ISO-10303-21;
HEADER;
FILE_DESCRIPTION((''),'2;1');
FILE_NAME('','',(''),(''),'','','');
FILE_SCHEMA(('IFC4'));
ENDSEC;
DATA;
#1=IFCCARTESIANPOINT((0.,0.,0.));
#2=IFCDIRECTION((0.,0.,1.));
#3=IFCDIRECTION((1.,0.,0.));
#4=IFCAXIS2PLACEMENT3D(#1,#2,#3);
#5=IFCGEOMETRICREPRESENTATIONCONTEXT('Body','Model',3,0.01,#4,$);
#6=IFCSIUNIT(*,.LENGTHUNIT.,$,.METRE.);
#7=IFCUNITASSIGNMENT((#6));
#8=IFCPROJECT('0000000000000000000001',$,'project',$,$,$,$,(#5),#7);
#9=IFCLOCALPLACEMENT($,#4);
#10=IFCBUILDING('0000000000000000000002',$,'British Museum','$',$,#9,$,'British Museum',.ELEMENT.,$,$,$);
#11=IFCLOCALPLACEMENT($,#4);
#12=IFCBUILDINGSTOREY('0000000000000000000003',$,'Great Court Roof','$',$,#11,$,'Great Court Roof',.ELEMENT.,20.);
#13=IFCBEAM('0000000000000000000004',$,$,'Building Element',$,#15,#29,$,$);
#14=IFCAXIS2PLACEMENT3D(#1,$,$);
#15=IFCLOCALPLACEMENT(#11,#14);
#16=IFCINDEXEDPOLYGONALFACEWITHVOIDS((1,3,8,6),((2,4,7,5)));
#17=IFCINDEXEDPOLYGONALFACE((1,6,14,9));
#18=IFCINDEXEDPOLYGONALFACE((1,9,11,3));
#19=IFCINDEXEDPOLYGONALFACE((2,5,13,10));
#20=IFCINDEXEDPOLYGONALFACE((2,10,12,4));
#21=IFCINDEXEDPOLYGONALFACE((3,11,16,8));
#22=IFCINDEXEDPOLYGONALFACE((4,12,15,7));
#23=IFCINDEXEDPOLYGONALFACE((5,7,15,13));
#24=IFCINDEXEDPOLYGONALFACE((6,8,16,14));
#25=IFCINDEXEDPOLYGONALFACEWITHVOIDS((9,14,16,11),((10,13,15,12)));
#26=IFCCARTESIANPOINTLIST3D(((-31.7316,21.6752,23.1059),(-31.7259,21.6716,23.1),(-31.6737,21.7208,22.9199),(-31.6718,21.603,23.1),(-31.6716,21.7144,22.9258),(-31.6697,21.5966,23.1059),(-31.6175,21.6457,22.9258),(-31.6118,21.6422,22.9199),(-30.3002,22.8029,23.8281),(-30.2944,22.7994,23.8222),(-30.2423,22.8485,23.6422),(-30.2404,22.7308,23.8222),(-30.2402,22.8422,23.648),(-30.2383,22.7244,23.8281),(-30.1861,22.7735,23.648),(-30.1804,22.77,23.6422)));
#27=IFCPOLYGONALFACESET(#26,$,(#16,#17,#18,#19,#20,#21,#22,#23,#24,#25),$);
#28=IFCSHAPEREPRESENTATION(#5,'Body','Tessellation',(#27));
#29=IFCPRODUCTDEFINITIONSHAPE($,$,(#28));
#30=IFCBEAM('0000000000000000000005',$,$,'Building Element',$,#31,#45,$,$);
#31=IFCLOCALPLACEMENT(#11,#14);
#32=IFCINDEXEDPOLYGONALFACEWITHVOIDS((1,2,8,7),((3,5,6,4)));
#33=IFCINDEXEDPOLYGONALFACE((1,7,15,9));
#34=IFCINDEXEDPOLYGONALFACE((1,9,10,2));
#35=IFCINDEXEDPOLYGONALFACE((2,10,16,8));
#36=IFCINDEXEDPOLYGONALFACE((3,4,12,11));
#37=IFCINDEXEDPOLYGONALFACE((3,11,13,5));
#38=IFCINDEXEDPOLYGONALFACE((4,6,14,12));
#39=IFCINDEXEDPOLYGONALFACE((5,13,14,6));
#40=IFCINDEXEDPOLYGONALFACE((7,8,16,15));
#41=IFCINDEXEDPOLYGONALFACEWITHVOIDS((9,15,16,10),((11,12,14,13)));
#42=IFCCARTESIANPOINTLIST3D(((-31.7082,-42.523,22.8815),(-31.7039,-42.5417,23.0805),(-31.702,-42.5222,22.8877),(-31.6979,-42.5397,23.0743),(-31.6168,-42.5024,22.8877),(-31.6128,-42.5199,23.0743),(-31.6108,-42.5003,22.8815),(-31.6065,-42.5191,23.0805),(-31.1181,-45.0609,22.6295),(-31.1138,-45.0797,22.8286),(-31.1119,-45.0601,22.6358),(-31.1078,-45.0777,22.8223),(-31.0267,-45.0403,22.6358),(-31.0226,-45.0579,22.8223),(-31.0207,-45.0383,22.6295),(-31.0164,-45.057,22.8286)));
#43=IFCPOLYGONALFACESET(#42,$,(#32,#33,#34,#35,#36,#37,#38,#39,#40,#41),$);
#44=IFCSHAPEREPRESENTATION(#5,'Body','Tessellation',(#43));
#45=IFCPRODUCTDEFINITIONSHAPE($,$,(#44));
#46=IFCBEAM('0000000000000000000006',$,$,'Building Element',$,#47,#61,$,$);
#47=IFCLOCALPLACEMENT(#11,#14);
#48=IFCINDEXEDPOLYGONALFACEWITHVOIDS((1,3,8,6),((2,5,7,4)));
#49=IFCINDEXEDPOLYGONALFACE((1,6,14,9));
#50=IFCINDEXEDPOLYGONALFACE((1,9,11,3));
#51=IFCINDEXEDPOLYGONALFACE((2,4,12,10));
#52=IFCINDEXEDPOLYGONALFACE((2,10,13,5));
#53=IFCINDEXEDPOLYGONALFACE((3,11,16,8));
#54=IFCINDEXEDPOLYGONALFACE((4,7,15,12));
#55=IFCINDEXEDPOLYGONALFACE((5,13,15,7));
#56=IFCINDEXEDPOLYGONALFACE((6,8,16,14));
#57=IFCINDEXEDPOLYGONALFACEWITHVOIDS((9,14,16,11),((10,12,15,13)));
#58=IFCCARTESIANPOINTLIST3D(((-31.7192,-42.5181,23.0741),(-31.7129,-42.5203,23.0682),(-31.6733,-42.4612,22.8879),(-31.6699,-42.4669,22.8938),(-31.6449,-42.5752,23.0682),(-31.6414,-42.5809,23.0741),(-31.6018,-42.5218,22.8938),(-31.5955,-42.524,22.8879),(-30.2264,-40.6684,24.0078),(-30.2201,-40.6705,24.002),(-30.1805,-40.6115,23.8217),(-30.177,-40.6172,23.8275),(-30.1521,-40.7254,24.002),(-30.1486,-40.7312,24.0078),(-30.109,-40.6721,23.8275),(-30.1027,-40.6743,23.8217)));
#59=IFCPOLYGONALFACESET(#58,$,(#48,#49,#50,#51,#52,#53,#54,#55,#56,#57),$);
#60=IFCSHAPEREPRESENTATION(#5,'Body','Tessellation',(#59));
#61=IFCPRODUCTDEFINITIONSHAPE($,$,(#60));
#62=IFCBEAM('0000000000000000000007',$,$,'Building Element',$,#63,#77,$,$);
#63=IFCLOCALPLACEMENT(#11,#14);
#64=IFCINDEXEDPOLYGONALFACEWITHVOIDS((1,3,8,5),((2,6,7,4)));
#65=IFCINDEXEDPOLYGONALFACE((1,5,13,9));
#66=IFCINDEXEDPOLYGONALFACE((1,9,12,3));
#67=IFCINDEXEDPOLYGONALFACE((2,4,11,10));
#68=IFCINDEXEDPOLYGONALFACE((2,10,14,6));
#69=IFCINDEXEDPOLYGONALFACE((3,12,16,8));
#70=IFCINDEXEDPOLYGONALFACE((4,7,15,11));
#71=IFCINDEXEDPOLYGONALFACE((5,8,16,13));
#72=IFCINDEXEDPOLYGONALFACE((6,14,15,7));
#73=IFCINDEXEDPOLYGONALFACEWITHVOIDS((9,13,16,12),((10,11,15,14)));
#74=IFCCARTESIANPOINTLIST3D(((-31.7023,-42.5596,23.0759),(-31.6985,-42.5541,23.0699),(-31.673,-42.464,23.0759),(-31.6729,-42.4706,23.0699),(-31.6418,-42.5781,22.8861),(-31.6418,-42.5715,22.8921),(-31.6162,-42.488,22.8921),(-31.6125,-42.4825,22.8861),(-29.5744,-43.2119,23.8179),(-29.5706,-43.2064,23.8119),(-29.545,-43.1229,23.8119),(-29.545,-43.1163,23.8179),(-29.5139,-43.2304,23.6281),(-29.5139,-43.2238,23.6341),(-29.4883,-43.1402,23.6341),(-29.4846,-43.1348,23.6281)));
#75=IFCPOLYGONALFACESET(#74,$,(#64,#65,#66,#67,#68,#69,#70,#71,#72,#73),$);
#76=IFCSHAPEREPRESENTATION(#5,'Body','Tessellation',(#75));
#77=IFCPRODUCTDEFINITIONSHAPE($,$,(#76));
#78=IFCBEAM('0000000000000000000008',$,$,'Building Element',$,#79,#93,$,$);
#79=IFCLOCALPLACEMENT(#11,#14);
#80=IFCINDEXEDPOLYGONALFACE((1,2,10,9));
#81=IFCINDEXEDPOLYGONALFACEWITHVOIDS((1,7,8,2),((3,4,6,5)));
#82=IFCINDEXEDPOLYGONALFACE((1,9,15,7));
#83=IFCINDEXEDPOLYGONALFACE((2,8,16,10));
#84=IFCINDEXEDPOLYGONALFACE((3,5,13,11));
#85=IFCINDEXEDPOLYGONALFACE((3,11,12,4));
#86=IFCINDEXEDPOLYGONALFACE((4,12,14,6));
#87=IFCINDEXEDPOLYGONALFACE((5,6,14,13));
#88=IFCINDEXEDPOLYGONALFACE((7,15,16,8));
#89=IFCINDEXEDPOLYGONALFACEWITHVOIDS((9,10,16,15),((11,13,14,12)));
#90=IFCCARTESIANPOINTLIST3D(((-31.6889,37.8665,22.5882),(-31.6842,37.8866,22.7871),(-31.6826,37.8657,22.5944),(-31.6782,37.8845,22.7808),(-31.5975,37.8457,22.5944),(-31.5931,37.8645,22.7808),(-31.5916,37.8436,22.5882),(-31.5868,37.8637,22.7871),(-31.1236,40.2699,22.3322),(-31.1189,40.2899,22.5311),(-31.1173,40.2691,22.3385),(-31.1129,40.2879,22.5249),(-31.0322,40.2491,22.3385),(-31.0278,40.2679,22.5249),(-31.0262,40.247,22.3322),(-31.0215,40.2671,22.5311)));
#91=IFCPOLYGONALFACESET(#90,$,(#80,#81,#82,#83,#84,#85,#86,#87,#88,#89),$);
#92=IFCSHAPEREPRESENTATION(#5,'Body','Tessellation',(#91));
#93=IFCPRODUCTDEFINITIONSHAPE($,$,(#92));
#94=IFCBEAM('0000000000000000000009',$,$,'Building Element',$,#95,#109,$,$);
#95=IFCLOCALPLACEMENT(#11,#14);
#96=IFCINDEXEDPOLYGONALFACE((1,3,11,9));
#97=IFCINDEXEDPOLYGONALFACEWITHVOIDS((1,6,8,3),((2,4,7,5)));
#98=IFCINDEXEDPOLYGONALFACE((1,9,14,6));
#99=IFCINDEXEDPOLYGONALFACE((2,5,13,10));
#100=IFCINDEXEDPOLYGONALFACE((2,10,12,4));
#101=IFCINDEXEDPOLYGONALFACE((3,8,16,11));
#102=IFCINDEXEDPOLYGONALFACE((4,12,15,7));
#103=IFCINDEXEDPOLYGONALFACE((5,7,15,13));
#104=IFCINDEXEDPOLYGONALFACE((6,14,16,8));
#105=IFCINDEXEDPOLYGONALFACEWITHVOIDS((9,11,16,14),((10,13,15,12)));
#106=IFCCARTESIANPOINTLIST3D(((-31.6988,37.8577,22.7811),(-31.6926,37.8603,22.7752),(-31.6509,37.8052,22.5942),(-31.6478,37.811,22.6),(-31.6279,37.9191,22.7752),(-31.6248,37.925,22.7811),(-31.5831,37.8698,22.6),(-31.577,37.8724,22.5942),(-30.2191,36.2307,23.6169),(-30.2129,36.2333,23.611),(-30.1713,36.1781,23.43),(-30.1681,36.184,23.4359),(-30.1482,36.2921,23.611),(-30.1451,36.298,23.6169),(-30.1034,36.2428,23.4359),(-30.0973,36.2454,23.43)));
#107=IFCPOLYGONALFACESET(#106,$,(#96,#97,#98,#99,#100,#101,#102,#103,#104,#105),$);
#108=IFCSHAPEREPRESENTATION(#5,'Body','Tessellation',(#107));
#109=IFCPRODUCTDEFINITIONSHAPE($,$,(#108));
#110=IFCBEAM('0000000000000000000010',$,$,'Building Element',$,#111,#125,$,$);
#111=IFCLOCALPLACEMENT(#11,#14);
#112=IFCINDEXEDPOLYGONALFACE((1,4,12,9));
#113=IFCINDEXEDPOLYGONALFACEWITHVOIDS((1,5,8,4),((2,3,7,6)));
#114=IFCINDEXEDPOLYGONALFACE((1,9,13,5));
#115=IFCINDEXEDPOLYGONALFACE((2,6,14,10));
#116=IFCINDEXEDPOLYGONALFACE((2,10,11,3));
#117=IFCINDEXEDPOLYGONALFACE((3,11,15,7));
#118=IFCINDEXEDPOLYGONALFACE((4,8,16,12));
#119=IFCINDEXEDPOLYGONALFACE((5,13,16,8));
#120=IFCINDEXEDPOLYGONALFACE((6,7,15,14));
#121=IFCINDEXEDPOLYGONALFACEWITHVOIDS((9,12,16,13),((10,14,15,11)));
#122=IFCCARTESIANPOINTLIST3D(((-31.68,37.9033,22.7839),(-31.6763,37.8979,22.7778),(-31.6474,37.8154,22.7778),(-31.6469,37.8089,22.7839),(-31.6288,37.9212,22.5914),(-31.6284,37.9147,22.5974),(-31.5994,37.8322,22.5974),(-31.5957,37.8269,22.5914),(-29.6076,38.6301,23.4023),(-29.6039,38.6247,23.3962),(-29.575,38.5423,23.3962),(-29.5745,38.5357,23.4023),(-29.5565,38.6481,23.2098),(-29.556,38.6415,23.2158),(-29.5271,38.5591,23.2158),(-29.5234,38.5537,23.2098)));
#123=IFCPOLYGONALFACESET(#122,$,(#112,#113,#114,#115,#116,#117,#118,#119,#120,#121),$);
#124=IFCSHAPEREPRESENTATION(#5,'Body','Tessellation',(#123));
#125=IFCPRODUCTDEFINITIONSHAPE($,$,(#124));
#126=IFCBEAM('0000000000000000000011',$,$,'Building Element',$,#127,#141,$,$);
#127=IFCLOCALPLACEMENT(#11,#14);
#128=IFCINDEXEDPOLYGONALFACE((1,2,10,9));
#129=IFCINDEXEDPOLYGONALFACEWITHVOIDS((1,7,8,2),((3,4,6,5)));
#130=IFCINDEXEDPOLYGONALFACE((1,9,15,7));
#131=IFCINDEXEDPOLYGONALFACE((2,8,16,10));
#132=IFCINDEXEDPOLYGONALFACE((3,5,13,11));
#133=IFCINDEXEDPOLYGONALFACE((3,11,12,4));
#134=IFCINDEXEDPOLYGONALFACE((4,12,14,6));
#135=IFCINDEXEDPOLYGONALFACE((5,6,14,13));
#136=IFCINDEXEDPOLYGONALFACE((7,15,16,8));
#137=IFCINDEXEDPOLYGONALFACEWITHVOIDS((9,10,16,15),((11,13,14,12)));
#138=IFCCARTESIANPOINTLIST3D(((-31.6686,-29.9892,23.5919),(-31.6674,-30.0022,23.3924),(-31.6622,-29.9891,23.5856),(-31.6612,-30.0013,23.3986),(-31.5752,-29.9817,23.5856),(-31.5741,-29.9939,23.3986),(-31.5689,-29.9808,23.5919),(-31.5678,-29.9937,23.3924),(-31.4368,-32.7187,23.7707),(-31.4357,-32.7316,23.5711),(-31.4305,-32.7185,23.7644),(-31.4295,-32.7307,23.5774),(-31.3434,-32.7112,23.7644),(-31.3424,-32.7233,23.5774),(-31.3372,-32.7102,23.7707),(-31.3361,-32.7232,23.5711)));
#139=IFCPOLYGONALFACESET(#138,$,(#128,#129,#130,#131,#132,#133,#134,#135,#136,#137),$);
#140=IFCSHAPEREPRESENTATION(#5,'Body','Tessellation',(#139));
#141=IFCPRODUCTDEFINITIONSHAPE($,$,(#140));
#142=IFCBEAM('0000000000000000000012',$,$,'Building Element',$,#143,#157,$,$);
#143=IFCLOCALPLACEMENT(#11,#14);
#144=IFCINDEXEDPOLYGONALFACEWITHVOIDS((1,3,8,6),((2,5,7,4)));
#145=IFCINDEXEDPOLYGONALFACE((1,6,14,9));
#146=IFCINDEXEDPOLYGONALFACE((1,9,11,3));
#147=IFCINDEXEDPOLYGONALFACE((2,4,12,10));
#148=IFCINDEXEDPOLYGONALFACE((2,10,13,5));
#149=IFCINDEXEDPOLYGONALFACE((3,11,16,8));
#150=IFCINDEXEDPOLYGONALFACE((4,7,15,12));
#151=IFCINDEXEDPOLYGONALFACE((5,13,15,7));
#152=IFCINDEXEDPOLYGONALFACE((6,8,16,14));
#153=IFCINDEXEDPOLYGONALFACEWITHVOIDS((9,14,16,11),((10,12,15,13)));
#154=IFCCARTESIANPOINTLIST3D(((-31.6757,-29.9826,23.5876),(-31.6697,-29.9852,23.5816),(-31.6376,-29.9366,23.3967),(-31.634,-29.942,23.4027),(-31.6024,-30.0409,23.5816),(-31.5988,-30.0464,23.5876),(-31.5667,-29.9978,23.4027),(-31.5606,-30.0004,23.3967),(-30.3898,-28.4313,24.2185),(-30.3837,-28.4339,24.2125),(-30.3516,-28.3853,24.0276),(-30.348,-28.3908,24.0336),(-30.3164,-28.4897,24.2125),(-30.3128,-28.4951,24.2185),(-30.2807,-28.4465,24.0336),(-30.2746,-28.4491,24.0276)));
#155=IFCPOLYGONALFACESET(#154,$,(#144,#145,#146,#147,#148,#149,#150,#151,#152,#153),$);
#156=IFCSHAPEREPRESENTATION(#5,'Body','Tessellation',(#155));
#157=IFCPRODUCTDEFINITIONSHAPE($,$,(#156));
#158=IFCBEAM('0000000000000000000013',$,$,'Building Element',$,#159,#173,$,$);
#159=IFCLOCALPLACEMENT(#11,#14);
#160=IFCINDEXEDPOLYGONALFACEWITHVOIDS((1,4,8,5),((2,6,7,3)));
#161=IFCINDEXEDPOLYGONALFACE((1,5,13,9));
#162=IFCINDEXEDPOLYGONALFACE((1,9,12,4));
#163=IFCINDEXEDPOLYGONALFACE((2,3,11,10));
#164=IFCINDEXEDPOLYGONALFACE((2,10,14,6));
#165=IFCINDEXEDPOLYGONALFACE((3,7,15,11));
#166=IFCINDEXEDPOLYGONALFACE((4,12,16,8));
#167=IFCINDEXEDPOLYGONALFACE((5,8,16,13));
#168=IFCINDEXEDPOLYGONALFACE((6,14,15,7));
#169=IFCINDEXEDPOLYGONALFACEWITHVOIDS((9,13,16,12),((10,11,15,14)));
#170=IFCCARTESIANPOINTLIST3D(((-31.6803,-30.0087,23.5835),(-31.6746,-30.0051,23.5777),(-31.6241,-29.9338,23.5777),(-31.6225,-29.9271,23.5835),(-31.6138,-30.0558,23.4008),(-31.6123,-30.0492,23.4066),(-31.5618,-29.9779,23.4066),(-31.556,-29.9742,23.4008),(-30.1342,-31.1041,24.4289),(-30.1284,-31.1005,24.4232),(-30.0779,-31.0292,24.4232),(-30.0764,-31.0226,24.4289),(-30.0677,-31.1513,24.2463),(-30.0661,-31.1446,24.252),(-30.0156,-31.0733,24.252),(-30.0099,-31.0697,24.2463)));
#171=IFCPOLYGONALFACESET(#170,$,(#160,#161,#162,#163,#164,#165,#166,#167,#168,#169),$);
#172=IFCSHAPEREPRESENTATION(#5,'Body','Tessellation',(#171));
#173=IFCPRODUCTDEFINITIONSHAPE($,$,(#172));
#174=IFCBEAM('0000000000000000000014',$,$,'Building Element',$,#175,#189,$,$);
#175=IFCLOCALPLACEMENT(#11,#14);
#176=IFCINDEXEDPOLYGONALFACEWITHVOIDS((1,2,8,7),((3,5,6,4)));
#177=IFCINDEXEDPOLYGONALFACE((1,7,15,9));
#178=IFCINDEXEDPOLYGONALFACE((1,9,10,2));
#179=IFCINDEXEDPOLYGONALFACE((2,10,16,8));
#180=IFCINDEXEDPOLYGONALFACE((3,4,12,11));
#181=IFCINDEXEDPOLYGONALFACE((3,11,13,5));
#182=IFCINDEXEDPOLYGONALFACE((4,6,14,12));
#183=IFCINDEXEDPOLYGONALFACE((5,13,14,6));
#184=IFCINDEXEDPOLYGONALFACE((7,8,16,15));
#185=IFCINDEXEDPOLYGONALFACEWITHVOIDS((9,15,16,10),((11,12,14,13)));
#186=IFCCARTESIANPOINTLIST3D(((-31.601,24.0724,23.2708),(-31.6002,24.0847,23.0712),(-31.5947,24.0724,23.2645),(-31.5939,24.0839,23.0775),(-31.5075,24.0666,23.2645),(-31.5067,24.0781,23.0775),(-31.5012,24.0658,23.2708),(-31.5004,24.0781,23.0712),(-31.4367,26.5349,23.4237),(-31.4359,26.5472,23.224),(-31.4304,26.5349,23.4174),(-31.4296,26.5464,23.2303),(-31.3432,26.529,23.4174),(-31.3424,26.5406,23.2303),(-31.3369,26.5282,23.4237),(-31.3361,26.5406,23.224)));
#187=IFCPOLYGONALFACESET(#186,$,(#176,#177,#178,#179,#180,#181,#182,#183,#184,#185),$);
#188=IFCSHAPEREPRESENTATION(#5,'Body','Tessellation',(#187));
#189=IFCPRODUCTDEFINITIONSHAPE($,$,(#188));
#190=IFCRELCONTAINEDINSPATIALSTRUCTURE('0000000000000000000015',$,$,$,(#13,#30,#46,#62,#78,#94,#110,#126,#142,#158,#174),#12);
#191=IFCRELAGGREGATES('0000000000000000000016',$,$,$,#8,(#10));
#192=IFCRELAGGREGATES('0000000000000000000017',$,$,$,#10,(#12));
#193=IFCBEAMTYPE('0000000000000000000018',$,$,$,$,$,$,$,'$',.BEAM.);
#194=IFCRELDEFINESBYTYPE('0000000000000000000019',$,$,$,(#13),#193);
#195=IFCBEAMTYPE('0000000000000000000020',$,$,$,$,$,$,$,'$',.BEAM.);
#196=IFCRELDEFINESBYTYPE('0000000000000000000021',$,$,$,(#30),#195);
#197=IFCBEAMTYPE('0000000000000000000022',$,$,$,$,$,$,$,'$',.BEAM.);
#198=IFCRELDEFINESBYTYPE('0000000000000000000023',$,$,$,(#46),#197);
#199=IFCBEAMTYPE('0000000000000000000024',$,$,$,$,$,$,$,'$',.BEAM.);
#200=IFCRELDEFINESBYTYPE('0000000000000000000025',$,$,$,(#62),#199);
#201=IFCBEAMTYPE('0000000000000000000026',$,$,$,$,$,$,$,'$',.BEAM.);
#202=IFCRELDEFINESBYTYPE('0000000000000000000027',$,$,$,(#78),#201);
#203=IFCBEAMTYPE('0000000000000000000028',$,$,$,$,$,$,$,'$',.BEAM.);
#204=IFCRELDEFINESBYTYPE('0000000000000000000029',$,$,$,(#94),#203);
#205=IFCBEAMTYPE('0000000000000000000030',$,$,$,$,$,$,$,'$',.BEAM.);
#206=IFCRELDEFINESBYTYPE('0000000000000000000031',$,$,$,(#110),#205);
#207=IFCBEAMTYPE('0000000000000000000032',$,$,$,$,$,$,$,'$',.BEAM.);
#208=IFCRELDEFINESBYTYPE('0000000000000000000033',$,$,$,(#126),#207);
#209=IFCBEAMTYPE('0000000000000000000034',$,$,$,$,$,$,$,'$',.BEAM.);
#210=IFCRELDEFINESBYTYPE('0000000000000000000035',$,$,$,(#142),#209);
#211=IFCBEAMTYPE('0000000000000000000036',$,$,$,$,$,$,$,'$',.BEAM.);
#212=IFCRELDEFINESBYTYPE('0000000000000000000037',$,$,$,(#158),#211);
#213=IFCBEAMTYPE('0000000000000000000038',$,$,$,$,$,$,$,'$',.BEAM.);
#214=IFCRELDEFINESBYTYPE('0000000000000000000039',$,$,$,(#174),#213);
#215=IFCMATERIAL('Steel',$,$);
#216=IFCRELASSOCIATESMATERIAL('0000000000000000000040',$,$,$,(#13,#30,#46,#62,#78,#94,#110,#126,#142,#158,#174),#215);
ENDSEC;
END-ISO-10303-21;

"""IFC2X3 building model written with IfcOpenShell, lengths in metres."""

from ifc_helpers import new_model, si_unit, frame, origin_with_axes, origin_2d, place, context, project, spatial, hollow_rectangle, extrude, material, type_object, element, save


model = new_model("IFC2X3")

# Units and contexts
model_context = context("Model", 3, precision=0.01, world=origin_with_axes(), identifier="Body")
ifc_project = project(units=[si_unit("LENGTHUNIT", "METRE")], contexts=[model_context])

# Building, storey
building_placement = place(None, origin_with_axes())
building = spatial("IfcBuilding", under=ifc_project, at=building_placement, Name="British Museum", Description="$", LongName="British Museum", CompositionType="ELEMENT")
storey_placement = place(None, origin_with_axes())
storey = spatial("IfcBuildingStorey", under=building, at=storey_placement, Name="Great Court Roof", Description="$", LongName="Great Court Roof", CompositionType="ELEMENT", Elevation=20.0)

# Beams
ifc_material = material(Name="Steel")
beam_type_1 = type_object("IfcBeamType", ElementType="$", PredefinedType="BEAM")
beam_1_placement = place(None, origin_with_axes())
element("IfcBeam", 1, at=beam_1_placement, inside=storey, type_object=beam_type_1, material=ifc_material, Description="Building Element", context=model_context, shape_type="SweptSolid", body=[
    extrude(hollow_rectangle(XDim=0.1, YDim=0.2, WallThickness=0.0063, InnerFilletRadius=-0.0063, OuterFilletRadius=0.0, at=origin_2d()), frame((-31.6717, 21.6587, 23.0129), z_axis=(0.730235, 0.575332, 0.368442), x_axis=(-0.61887, 0.785494, 0.0)), (0.0, 0.0, 1.0), 1.9602),
])
beam_type_2 = type_object("IfcBeamType", ElementType="$", PredefinedType="BEAM")
beam_2_placement = place(None, origin_with_axes())
element("IfcBeam", 2, at=beam_2_placement, inside=storey, type_object=beam_type_2, material=ifc_material, Description="Building Element", context=model_context, shape_type="SweptSolid", body=[
    extrude(hollow_rectangle(XDim=0.1, YDim=0.2, WallThickness=0.0063, InnerFilletRadius=-0.0063, OuterFilletRadius=0.0, at=origin_2d()), frame((-31.6574, -42.521, 22.981), z_axis=(0.225423, -0.969495, -0.096244), x_axis=(0.974017, 0.226475, 0.0)), (0.0, 0.0, 1.0), 2.6178),
])
beam_type_3 = type_object("IfcBeamType", ElementType="$", PredefinedType="BEAM")
beam_3_placement = place(None, origin_with_axes())
element("IfcBeam", 3, at=beam_3_placement, inside=storey, type_object=beam_type_3, material=ifc_material, Description="Building Element", context=model_context, shape_type="SweptSolid", body=[
    extrude(hollow_rectangle(XDim=0.1, YDim=0.2, WallThickness=0.0063, InnerFilletRadius=-0.0063, OuterFilletRadius=0.0, at=origin_2d()), frame((-31.6574, -42.521, 22.981), z_axis=(0.584547, 0.724304, 0.365635), x_axis=(-0.778187, 0.628033, 0.0)), (0.0, 0.0, 1.0), 2.5538),
])
beam_type_4 = type_object("IfcBeamType", ElementType="$", PredefinedType="BEAM")
beam_4_placement = place(None, origin_with_axes())
element("IfcBeam", 4, at=beam_4_placement, inside=storey, type_object=beam_type_4, material=ifc_material, Description="Building Element", context=model_context, shape_type="SweptSolid", body=[
    extrude(hollow_rectangle(XDim=0.1, YDim=0.2, WallThickness=0.0063, InnerFilletRadius=-0.0063, OuterFilletRadius=0.0, at=origin_2d()), frame((-31.6574, -42.521, 22.981), z_axis=(0.90701, -0.278036, 0.316274), x_axis=(0.293081, 0.956088, 0.0)), (0.0, 0.0, 1.0), 2.3461),
])
beam_type_5 = type_object("IfcBeamType", ElementType="$", PredefinedType="BEAM")
beam_5_placement = place(None, origin_with_axes())
element("IfcBeam", 5, at=beam_5_placement, inside=storey, type_object=beam_type_5, material=ifc_material, Description="Building Element", context=model_context, shape_type="SweptSolid", body=[
    extrude(hollow_rectangle(XDim=0.1, YDim=0.2, WallThickness=0.0063, InnerFilletRadius=-0.0063, OuterFilletRadius=0.0, at=origin_2d()), frame((-31.6379, 37.8651, 22.6876), z_axis=(0.227743, 0.968246, -0.103116), x_axis=(-0.973435, 0.228964, 0.0)), (0.0, 0.0, 1.0), 2.4822),
])
beam_type_6 = type_object("IfcBeamType", ElementType="$", PredefinedType="BEAM")
beam_6_placement = place(None, origin_with_axes())
element("IfcBeam", 6, at=beam_6_placement, inside=storey, type_object=beam_type_6, material=ifc_material, Description="Building Element", context=model_context, shape_type="SweptSolid", body=[
    extrude(hollow_rectangle(XDim=0.1, YDim=0.2, WallThickness=0.0063, InnerFilletRadius=-0.0063, OuterFilletRadius=0.0, at=origin_2d()), frame((-31.6379, 37.8651, 22.6876), z_axis=(0.628929, -0.691549, 0.355258), x_axis=(0.739808, 0.672818, 0.0)), (0.0, 0.0, 1.0), 2.3527),
])
beam_type_7 = type_object("IfcBeamType", ElementType="$", PredefinedType="BEAM")
beam_7_placement = place(None, origin_with_axes())
element("IfcBeam", 7, at=beam_7_placement, inside=storey, type_object=beam_type_7, material=ifc_material, Description="Building Element", context=model_context, shape_type="SweptSolid", body=[
    extrude(hollow_rectangle(XDim=0.1, YDim=0.2, WallThickness=0.0063, InnerFilletRadius=-0.0063, OuterFilletRadius=0.0, at=origin_2d()), frame((-31.6379, 37.8651, 22.6876), z_axis=(0.908321, 0.318572, 0.271044), x_axis=(-0.33096, 0.943645, 0.0)), (0.0, 0.0, 1.0), 2.2815),
])
beam_type_8 = type_object("IfcBeamType", ElementType="$", PredefinedType="BEAM")
beam_8_placement = place(None, origin_with_axes())
element("IfcBeam", 8, at=beam_8_placement, inside=storey, type_object=beam_type_8, material=ifc_material, Description="Building Element", context=model_context, shape_type="SweptSolid", body=[
    extrude(hollow_rectangle(XDim=0.1, YDim=0.2, WallThickness=0.0063, InnerFilletRadius=-0.0063, OuterFilletRadius=0.0, at=origin_2d()), frame((-31.6182, -29.9915, 23.4921), z_axis=(0.084408, -0.994301, 0.065126), x_axis=(0.996416, 0.084587, 0.0)), (0.0, 0.0, 1.0), 2.7451),
])
beam_type_9 = type_object("IfcBeamType", ElementType="$", PredefinedType="BEAM")
beam_9_placement = place(None, origin_with_axes())
element("IfcBeam", 9, at=beam_9_placement, inside=storey, type_object=beam_type_9, material=ifc_material, Description="Building Element", context=model_context, shape_type="SweptSolid", body=[
    extrude(hollow_rectangle(XDim=0.1, YDim=0.2, WallThickness=0.0063, InnerFilletRadius=-0.0063, OuterFilletRadius=0.0, at=origin_2d()), frame((-31.6182, -29.9915, 23.4921), z_axis=(0.609043, 0.734696, 0.298811), x_axis=(-0.76987, 0.638201, 0.0)), (0.0, 0.0, 1.0), 2.1115),
])
beam_type_10 = type_object("IfcBeamType", ElementType="$", PredefinedType="BEAM")
beam_10_placement = place(None, origin_with_axes())
element("IfcBeam", 10, at=beam_10_placement, inside=storey, type_object=beam_type_10, material=ifc_material, Description="Building Element", context=model_context, shape_type="SweptSolid", body=[
    extrude(hollow_rectangle(XDim=0.1, YDim=0.2, WallThickness=0.0063, InnerFilletRadius=-0.0063, OuterFilletRadius=0.0, at=origin_2d()), frame((-31.6182, -29.9915, 23.4921), z_axis=(0.745159, -0.527931, 0.407464), x_axis=(0.578098, 0.815968, 0.0)), (0.0, 0.0, 1.0), 2.0749),
])
beam_type_11 = type_object("IfcBeamType", ElementType="$", PredefinedType="BEAM")
beam_11_placement = place(None, origin_with_axes())
element("IfcBeam", 11, at=beam_11_placement, inside=storey, type_object=beam_type_11, material=ifc_material, Description="Building Element", context=model_context, shape_type="SweptSolid", body=[
    extrude(hollow_rectangle(XDim=0.1, YDim=0.2, WallThickness=0.0063, InnerFilletRadius=-0.0063, OuterFilletRadius=0.0, at=origin_2d()), frame((-31.5507, 24.0753, 23.171), z_axis=(0.066435, 0.995875, 0.061804), x_axis=(-0.997782, 0.066562, 0.0)), (0.0, 0.0, 1.0), 2.4727),
])

save(model, "model.ifc")
